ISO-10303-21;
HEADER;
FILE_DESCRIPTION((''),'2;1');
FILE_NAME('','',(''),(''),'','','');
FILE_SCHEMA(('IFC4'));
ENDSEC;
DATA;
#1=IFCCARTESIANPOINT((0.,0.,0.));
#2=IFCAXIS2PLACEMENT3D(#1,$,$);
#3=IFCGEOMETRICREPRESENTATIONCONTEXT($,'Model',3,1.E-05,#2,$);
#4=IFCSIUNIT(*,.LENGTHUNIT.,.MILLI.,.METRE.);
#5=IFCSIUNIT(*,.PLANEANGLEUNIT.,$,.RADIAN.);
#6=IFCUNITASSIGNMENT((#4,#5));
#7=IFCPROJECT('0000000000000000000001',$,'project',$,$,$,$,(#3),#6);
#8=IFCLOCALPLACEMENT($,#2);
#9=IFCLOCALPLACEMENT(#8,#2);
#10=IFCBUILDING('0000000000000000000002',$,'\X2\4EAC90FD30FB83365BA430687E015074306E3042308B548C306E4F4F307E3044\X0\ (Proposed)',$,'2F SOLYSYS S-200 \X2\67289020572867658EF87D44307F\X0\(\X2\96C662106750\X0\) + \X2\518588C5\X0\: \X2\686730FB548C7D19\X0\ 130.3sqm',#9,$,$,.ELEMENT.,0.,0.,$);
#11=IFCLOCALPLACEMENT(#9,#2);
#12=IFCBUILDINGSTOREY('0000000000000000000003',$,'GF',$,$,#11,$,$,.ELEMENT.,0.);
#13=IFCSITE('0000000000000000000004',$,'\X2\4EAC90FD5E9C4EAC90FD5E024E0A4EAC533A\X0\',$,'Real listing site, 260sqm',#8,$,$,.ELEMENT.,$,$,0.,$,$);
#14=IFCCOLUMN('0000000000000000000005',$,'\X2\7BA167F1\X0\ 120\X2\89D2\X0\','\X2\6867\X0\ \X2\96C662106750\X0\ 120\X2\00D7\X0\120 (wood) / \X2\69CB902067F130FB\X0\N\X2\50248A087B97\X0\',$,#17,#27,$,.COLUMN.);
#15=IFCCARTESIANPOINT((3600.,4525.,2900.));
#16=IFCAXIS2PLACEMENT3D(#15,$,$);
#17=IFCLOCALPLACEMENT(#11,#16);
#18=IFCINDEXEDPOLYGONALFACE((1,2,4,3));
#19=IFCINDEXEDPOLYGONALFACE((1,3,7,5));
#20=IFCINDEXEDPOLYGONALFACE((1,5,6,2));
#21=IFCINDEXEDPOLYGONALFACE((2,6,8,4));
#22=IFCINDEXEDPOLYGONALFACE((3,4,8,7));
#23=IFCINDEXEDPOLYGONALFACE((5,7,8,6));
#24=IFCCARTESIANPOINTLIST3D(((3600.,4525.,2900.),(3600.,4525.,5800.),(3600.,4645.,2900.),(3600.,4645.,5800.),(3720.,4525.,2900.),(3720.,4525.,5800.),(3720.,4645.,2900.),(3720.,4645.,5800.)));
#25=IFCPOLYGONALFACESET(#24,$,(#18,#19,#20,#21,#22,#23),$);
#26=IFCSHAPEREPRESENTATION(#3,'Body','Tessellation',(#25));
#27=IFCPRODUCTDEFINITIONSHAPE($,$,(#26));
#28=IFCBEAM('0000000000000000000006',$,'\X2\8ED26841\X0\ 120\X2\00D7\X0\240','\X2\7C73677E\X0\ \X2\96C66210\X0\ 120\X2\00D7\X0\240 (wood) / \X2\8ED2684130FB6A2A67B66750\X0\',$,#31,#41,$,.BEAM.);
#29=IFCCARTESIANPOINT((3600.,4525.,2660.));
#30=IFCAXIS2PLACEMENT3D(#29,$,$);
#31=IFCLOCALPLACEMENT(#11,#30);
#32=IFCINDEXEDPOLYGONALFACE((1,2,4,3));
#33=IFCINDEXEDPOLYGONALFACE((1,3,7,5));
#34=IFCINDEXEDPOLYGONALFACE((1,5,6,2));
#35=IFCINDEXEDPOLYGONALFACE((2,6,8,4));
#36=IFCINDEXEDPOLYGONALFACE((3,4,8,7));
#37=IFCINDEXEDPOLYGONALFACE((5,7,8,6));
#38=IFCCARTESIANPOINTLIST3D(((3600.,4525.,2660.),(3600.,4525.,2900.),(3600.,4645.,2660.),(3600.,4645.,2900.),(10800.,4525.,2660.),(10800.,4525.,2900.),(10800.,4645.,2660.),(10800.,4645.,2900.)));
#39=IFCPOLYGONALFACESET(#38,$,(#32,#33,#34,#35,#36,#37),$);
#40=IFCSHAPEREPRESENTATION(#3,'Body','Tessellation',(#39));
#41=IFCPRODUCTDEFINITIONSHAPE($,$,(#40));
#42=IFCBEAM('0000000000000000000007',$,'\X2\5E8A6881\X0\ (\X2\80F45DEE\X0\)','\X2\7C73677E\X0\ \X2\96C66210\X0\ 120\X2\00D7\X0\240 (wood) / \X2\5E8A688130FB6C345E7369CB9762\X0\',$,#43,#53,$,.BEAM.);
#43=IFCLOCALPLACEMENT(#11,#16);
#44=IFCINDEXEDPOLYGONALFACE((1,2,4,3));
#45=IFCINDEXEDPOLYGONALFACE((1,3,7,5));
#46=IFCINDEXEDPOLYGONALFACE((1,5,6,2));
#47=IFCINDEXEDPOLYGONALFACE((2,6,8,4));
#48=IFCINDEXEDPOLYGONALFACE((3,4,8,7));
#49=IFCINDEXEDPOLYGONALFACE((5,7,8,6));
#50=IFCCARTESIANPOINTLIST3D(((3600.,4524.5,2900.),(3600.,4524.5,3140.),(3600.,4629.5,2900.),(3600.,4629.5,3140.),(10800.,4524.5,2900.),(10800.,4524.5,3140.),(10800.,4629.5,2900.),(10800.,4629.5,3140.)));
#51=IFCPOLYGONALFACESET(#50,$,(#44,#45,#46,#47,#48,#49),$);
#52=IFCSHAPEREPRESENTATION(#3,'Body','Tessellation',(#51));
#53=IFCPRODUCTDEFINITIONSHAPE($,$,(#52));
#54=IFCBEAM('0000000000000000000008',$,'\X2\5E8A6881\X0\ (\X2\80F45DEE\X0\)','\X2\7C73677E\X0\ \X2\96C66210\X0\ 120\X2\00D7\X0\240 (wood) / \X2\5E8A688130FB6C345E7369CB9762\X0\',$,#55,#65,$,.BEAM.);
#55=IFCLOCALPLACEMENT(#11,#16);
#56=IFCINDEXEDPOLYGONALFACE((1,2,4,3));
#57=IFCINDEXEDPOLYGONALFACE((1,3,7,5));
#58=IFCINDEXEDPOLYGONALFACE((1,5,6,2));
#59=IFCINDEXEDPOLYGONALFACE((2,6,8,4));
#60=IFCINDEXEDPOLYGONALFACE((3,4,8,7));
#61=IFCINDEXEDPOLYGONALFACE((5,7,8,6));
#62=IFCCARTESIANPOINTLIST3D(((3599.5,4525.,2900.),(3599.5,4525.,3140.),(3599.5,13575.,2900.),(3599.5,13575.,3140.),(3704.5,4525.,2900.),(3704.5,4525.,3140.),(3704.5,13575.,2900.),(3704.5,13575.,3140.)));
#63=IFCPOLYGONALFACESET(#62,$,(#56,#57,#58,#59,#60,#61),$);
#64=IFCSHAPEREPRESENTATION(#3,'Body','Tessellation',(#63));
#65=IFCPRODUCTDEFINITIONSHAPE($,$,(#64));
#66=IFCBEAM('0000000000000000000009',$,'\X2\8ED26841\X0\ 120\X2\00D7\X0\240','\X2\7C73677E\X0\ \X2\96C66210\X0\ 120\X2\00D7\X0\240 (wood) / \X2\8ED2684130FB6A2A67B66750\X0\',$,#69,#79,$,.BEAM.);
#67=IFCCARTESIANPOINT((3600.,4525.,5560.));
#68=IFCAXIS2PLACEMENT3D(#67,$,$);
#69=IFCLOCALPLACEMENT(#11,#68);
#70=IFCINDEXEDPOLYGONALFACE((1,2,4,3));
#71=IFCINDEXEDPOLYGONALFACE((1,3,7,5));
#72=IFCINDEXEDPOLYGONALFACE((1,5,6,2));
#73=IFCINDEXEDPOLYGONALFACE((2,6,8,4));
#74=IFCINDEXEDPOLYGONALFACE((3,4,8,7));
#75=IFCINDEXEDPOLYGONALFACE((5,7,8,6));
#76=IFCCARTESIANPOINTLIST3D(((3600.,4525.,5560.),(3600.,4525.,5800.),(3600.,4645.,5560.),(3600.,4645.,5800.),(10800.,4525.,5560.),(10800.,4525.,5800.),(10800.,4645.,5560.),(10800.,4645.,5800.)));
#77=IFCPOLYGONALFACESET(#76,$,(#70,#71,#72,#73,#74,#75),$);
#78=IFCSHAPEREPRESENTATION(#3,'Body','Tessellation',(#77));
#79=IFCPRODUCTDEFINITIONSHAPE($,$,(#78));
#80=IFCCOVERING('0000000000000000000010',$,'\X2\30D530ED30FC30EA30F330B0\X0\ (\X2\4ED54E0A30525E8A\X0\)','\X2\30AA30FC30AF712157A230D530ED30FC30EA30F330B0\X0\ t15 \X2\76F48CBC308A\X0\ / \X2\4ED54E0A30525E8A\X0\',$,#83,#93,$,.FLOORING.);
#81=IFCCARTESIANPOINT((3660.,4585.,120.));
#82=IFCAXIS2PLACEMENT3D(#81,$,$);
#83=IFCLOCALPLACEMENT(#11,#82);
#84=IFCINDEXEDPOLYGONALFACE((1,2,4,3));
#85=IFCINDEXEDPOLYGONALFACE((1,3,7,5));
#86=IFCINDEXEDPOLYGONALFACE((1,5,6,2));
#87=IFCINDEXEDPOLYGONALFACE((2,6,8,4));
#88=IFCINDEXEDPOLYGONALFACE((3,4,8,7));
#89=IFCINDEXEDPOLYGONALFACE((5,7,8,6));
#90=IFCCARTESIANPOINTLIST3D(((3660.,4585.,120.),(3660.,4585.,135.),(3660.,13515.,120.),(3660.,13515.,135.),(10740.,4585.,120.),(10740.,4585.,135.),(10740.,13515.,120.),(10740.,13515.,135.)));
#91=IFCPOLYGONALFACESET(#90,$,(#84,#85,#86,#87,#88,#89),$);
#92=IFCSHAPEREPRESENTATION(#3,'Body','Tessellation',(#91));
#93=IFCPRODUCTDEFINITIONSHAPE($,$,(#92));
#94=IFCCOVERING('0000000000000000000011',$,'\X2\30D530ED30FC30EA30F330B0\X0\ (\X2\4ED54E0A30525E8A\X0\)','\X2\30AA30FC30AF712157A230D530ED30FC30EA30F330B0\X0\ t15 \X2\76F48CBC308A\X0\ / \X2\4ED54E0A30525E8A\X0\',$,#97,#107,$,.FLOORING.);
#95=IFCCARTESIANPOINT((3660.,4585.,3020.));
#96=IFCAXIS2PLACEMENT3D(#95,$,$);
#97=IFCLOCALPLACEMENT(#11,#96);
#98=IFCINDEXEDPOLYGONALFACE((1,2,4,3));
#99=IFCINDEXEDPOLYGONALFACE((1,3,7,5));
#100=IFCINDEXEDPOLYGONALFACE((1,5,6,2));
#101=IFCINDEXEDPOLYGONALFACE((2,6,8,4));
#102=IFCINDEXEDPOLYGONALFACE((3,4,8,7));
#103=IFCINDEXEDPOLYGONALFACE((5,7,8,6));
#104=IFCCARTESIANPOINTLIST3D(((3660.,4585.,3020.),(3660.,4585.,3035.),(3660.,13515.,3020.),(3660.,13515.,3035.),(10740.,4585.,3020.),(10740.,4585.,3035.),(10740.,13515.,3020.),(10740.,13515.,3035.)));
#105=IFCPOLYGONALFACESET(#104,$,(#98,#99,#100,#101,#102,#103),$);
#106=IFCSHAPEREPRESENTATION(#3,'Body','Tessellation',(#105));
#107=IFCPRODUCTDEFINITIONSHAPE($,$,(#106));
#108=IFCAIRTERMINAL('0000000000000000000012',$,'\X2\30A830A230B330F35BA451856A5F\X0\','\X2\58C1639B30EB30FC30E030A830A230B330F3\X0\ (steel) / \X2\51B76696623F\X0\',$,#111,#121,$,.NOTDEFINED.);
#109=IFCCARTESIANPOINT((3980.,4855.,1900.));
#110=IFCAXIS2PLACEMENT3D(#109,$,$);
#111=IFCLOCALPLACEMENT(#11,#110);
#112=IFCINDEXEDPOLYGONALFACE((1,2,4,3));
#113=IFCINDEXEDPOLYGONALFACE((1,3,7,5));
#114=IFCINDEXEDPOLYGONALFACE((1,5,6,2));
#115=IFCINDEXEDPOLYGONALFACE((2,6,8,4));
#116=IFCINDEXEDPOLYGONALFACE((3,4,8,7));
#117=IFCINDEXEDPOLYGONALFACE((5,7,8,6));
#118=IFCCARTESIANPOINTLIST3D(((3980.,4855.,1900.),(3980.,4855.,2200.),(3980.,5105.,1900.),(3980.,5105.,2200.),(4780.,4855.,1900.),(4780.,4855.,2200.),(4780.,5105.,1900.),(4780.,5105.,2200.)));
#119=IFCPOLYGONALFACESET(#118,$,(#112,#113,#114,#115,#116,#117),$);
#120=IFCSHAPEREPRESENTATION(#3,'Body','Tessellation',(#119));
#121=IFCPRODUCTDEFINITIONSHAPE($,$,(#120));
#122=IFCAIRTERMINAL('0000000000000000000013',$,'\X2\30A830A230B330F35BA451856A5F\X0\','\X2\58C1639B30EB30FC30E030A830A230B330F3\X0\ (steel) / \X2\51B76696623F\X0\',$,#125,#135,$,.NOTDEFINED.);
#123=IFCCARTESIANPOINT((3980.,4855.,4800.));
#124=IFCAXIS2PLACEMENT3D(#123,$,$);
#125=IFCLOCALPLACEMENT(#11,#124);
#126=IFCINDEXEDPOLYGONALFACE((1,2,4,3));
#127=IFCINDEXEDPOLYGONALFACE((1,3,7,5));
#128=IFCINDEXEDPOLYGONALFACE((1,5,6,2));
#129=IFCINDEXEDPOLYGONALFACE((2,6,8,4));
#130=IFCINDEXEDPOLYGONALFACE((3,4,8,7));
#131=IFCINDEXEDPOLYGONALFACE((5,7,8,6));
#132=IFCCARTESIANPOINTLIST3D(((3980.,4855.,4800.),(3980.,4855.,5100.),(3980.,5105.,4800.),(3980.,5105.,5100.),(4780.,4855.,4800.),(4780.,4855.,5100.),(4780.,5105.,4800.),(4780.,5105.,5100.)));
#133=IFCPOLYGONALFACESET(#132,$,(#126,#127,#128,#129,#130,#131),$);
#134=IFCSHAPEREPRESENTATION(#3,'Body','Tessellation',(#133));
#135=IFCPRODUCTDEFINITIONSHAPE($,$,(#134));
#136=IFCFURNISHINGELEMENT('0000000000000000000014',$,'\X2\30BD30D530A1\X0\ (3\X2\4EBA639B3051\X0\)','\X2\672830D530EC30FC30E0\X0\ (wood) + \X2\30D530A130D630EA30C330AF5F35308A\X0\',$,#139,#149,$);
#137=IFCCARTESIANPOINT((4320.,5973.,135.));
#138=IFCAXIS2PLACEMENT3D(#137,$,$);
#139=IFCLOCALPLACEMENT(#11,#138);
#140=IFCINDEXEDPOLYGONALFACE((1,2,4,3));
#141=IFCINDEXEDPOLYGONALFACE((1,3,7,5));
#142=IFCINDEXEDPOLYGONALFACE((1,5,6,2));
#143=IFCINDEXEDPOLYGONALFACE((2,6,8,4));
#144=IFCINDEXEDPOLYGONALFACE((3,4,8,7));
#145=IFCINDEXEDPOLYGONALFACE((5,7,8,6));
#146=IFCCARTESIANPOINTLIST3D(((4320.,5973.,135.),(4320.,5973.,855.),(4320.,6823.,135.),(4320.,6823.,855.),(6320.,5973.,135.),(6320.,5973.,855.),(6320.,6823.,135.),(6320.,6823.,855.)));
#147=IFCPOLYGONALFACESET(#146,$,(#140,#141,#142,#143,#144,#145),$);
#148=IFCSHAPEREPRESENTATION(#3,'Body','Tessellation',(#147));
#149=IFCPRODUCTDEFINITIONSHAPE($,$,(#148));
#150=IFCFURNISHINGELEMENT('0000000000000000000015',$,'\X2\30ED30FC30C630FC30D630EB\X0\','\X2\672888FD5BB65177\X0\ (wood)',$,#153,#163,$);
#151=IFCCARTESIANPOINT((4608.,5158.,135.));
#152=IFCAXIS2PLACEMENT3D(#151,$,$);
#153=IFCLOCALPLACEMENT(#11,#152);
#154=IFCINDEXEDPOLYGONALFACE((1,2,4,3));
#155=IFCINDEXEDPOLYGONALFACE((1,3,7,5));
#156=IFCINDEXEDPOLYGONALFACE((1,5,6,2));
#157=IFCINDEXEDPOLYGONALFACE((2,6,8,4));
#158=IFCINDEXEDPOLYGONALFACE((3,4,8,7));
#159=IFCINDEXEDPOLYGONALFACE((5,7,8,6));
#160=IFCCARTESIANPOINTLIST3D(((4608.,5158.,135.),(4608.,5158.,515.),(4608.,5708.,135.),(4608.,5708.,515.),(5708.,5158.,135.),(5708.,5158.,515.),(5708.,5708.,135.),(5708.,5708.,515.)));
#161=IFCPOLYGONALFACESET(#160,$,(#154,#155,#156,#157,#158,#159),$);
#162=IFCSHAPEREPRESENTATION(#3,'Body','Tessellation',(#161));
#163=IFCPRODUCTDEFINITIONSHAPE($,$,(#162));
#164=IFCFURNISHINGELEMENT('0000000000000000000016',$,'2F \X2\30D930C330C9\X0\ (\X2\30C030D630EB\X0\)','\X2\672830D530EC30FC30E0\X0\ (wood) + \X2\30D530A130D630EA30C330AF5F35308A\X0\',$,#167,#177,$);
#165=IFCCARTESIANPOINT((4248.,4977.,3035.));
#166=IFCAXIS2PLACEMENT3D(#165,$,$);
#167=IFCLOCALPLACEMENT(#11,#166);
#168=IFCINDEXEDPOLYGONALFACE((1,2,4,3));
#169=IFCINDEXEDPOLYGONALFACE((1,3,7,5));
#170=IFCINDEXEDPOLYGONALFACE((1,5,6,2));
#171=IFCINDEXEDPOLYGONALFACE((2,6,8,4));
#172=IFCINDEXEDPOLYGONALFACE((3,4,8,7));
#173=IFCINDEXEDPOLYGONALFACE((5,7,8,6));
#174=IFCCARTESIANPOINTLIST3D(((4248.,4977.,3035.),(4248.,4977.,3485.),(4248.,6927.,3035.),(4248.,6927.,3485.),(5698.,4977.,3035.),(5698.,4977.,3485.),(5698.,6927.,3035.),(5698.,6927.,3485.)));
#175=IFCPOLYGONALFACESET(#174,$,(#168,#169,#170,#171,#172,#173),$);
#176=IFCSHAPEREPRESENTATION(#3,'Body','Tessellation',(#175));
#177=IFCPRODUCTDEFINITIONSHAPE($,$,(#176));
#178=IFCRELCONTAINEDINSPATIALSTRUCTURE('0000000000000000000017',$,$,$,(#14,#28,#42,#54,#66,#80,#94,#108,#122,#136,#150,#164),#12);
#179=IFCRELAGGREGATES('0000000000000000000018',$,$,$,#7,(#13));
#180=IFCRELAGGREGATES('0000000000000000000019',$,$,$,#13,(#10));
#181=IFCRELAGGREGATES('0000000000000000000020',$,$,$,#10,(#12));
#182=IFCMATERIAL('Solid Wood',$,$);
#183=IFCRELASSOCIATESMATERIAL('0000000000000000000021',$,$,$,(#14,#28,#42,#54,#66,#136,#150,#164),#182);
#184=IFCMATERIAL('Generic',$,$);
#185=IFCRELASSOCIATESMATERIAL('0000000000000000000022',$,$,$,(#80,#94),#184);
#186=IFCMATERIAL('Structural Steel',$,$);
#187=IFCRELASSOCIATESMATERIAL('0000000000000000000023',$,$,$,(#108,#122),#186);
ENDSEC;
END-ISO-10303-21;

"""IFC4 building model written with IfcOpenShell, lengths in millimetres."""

from ifc_helpers import new_model, si_unit, frame, frame_2d, origin, place, context, project, spatial, rectangle, extrude, material, element, save


model = new_model("IFC4")

# Units and contexts
model_context = context("Model", 3, precision=1e-05, world=origin())
ifc_project = project(units=[si_unit("LENGTHUNIT", "METRE", prefix="MILLI"), si_unit("PLANEANGLEUNIT", "RADIAN")], contexts=[model_context])

# Site, building, storey
site_placement = place(None, origin())
site = spatial("IfcSite", under=ifc_project, at=site_placement, Name="京都府京都市上京区", ObjectType="Real listing site, 260sqm", CompositionType="ELEMENT", RefElevation=0.0)
building_placement = place(site_placement, origin())
building = spatial("IfcBuilding", under=site, at=building_placement, Name="京都・茶室と縁側のある和の住まい (Proposed)", ObjectType="2F SOLYSYS S-200 木造在来軸組み(集成材) + 内装: 桧・和紙 130.3sqm", CompositionType="ELEMENT", ElevationOfRefHeight=0.0, ElevationOfTerrain=0.0)
storey_placement = place(building_placement, origin())
storey = spatial("IfcBuildingStorey", under=building, at=storey_placement, Name="GF", CompositionType="ELEMENT", Elevation=0.0)

# Column
ifc_material_1 = material(Name="Solid Wood")
column_placement = place(storey_placement, frame((3600.0, 4525.0, 2900.0)))
element("IfcColumn", 1, at=column_placement, inside=storey, material=ifc_material_1, Name="管柱 120角", Description="桧 集成材 120×120 (wood) / 構造柱・N値計算", PredefinedType="COLUMN", context=model_context, shape_type="SweptSolid", body=[
    extrude(rectangle(XDim=120.0, YDim=120.0, at=frame_2d((60.0, 60.0))), frame((3600.0, 4525.0, 2900.0)), (0.0, 0.0, 1.0), 2900.0),
])

# Beams
beam_1_placement = place(storey_placement, frame((3600.0, 4525.0, 2660.0)))
element("IfcBeam", 2, at=beam_1_placement, inside=storey, material=ifc_material_1, Name="軒桁 120×240", Description="米松 集成 120×240 (wood) / 軒桁・横架材", PredefinedType="BEAM", context=model_context, shape_type="SweptSolid", body=[
    extrude(rectangle(XDim=7200.0, YDim=120.0, at=frame_2d((3600.0, 60.0))), frame((3600.0, 4525.0, 2660.0)), (0.0, 0.0, 1.0), 240.0),
])
beam_2_placement = place(storey_placement, frame((3600.0, 4525.0, 2900.0)))
element("IfcBeam", 3, at=beam_2_placement, inside=storey, material=ifc_material_1, Name="床梁 (胴差)", Description="米松 集成 120×240 (wood) / 床梁・水平構面", PredefinedType="BEAM", context=model_context, shape_type="SweptSolid", body=[
    extrude(rectangle(XDim=7200.0, YDim=105.0, at=frame_2d((3600.0, 52.0))), frame((3600.0, 4525.0, 2900.0)), (0.0, 0.0, 1.0), 240.0),
])
beam_3_placement = place(storey_placement, frame((3600.0, 4525.0, 2900.0)))
element("IfcBeam", 4, at=beam_3_placement, inside=storey, material=ifc_material_1, Name="床梁 (胴差)", Description="米松 集成 120×240 (wood) / 床梁・水平構面", PredefinedType="BEAM", context=model_context, shape_type="SweptSolid", body=[
    extrude(rectangle(XDim=105.0, YDim=9050.0, at=frame_2d((52.0, 4525.0))), frame((3600.0, 4525.0, 2900.0)), (0.0, 0.0, 1.0), 240.0),
])
beam_4_placement = place(storey_placement, frame((3600.0, 4525.0, 5560.0)))
element("IfcBeam", 5, at=beam_4_placement, inside=storey, material=ifc_material_1, Name="軒桁 120×240", Description="米松 集成 120×240 (wood) / 軒桁・横架材", PredefinedType="BEAM", context=model_context, shape_type="SweptSolid", body=[
    extrude(rectangle(XDim=7200.0, YDim=120.0, at=frame_2d((3600.0, 60.0))), frame((3600.0, 4525.0, 5560.0)), (0.0, 0.0, 1.0), 240.0),
])

# Coverings
ifc_material_2 = material(Name="Generic")
covering_1_placement = place(storey_placement, frame((3660.0, 4585.0, 120.0)))
element("IfcCovering", 6, at=covering_1_placement, inside=storey, material=ifc_material_2, Name="フローリング (仕上げ床)", Description="オーク無垢フローリング t15 直貼り / 仕上げ床", PredefinedType="FLOORING", context=model_context, shape_type="SweptSolid", body=[
    extrude(rectangle(XDim=7080.0, YDim=8930.0, at=frame_2d((3540.0, 4465.0))), frame((3660.0, 4585.0, 120.0)), (0.0, 0.0, 1.0), 15.0),
])
covering_2_placement = place(storey_placement, frame((3660.0, 4585.0, 3020.0)))
element("IfcCovering", 7, at=covering_2_placement, inside=storey, material=ifc_material_2, Name="フローリング (仕上げ床)", Description="オーク無垢フローリング t15 直貼り / 仕上げ床", PredefinedType="FLOORING", context=model_context, shape_type="SweptSolid", body=[
    extrude(rectangle(XDim=7080.0, YDim=8930.0, at=frame_2d((3540.0, 4465.0))), frame((3660.0, 4585.0, 3020.0)), (0.0, 0.0, 1.0), 15.0),
])

# Air terminals
ifc_material_3 = material(Name="Structural Steel")
air_terminal_1_placement = place(storey_placement, frame((3980.0, 4855.0, 1900.0)))
element("IfcAirTerminal", 8, at=air_terminal_1_placement, inside=storey, material=ifc_material_3, Name="エアコン室内機", Description="壁掛ルームエアコン (steel) / 冷暖房", PredefinedType="NOTDEFINED", context=model_context, shape_type="SweptSolid", body=[
    extrude(rectangle(XDim=800.0, YDim=250.0, at=frame_2d((400.0, 125.0))), frame((3980.0, 4855.0, 1900.0)), (0.0, 0.0, 1.0), 300.0),
])
air_terminal_2_placement = place(storey_placement, frame((3980.0, 4855.0, 4800.0)))
element("IfcAirTerminal", 9, at=air_terminal_2_placement, inside=storey, material=ifc_material_3, Name="エアコン室内機", Description="壁掛ルームエアコン (steel) / 冷暖房", PredefinedType="NOTDEFINED", context=model_context, shape_type="SweptSolid", body=[
    extrude(rectangle(XDim=800.0, YDim=250.0, at=frame_2d((400.0, 125.0))), frame((3980.0, 4855.0, 4800.0)), (0.0, 0.0, 1.0), 300.0),
])

# Furnishing elements
furnishing_1_placement = place(storey_placement, frame((4320.0, 5973.0, 135.0)))
element("IfcFurnishingElement", 10, at=furnishing_1_placement, inside=storey, material=ifc_material_1, Name="ソファ (3人掛け)", Description="木フレーム (wood) + ファブリック張り", context=model_context, shape_type="SweptSolid", body=[
    extrude(rectangle(XDim=2000.0, YDim=850.0, at=frame_2d((1000.0, 425.0))), frame((4320.0, 5973.0, 135.0)), (0.0, 0.0, 1.0), 720.0),
])
furnishing_2_placement = place(storey_placement, frame((4608.0, 5158.0, 135.0)))
element("IfcFurnishingElement", 11, at=furnishing_2_placement, inside=storey, material=ifc_material_1, Name="ローテーブル", Description="木製家具 (wood)", context=model_context, shape_type="SweptSolid", body=[
    extrude(rectangle(XDim=1100.0, YDim=550.0, at=frame_2d((550.0, 275.0))), frame((4608.0, 5158.0, 135.0)), (0.0, 0.0, 1.0), 380.0),
])
furnishing_3_placement = place(storey_placement, frame((4248.0, 4977.0, 3035.0)))
element("IfcFurnishingElement", 12, at=furnishing_3_placement, inside=storey, material=ifc_material_1, Name="2F ベッド (ダブル)", Description="木フレーム (wood) + ファブリック張り", context=model_context, shape_type="SweptSolid", body=[
    extrude(rectangle(XDim=1450.0, YDim=1950.0, at=frame_2d((725.0, 975.0))), frame((4248.0, 4977.0, 3035.0)), (0.0, 0.0, 1.0), 450.0),
])

save(model, "model.ifc")
